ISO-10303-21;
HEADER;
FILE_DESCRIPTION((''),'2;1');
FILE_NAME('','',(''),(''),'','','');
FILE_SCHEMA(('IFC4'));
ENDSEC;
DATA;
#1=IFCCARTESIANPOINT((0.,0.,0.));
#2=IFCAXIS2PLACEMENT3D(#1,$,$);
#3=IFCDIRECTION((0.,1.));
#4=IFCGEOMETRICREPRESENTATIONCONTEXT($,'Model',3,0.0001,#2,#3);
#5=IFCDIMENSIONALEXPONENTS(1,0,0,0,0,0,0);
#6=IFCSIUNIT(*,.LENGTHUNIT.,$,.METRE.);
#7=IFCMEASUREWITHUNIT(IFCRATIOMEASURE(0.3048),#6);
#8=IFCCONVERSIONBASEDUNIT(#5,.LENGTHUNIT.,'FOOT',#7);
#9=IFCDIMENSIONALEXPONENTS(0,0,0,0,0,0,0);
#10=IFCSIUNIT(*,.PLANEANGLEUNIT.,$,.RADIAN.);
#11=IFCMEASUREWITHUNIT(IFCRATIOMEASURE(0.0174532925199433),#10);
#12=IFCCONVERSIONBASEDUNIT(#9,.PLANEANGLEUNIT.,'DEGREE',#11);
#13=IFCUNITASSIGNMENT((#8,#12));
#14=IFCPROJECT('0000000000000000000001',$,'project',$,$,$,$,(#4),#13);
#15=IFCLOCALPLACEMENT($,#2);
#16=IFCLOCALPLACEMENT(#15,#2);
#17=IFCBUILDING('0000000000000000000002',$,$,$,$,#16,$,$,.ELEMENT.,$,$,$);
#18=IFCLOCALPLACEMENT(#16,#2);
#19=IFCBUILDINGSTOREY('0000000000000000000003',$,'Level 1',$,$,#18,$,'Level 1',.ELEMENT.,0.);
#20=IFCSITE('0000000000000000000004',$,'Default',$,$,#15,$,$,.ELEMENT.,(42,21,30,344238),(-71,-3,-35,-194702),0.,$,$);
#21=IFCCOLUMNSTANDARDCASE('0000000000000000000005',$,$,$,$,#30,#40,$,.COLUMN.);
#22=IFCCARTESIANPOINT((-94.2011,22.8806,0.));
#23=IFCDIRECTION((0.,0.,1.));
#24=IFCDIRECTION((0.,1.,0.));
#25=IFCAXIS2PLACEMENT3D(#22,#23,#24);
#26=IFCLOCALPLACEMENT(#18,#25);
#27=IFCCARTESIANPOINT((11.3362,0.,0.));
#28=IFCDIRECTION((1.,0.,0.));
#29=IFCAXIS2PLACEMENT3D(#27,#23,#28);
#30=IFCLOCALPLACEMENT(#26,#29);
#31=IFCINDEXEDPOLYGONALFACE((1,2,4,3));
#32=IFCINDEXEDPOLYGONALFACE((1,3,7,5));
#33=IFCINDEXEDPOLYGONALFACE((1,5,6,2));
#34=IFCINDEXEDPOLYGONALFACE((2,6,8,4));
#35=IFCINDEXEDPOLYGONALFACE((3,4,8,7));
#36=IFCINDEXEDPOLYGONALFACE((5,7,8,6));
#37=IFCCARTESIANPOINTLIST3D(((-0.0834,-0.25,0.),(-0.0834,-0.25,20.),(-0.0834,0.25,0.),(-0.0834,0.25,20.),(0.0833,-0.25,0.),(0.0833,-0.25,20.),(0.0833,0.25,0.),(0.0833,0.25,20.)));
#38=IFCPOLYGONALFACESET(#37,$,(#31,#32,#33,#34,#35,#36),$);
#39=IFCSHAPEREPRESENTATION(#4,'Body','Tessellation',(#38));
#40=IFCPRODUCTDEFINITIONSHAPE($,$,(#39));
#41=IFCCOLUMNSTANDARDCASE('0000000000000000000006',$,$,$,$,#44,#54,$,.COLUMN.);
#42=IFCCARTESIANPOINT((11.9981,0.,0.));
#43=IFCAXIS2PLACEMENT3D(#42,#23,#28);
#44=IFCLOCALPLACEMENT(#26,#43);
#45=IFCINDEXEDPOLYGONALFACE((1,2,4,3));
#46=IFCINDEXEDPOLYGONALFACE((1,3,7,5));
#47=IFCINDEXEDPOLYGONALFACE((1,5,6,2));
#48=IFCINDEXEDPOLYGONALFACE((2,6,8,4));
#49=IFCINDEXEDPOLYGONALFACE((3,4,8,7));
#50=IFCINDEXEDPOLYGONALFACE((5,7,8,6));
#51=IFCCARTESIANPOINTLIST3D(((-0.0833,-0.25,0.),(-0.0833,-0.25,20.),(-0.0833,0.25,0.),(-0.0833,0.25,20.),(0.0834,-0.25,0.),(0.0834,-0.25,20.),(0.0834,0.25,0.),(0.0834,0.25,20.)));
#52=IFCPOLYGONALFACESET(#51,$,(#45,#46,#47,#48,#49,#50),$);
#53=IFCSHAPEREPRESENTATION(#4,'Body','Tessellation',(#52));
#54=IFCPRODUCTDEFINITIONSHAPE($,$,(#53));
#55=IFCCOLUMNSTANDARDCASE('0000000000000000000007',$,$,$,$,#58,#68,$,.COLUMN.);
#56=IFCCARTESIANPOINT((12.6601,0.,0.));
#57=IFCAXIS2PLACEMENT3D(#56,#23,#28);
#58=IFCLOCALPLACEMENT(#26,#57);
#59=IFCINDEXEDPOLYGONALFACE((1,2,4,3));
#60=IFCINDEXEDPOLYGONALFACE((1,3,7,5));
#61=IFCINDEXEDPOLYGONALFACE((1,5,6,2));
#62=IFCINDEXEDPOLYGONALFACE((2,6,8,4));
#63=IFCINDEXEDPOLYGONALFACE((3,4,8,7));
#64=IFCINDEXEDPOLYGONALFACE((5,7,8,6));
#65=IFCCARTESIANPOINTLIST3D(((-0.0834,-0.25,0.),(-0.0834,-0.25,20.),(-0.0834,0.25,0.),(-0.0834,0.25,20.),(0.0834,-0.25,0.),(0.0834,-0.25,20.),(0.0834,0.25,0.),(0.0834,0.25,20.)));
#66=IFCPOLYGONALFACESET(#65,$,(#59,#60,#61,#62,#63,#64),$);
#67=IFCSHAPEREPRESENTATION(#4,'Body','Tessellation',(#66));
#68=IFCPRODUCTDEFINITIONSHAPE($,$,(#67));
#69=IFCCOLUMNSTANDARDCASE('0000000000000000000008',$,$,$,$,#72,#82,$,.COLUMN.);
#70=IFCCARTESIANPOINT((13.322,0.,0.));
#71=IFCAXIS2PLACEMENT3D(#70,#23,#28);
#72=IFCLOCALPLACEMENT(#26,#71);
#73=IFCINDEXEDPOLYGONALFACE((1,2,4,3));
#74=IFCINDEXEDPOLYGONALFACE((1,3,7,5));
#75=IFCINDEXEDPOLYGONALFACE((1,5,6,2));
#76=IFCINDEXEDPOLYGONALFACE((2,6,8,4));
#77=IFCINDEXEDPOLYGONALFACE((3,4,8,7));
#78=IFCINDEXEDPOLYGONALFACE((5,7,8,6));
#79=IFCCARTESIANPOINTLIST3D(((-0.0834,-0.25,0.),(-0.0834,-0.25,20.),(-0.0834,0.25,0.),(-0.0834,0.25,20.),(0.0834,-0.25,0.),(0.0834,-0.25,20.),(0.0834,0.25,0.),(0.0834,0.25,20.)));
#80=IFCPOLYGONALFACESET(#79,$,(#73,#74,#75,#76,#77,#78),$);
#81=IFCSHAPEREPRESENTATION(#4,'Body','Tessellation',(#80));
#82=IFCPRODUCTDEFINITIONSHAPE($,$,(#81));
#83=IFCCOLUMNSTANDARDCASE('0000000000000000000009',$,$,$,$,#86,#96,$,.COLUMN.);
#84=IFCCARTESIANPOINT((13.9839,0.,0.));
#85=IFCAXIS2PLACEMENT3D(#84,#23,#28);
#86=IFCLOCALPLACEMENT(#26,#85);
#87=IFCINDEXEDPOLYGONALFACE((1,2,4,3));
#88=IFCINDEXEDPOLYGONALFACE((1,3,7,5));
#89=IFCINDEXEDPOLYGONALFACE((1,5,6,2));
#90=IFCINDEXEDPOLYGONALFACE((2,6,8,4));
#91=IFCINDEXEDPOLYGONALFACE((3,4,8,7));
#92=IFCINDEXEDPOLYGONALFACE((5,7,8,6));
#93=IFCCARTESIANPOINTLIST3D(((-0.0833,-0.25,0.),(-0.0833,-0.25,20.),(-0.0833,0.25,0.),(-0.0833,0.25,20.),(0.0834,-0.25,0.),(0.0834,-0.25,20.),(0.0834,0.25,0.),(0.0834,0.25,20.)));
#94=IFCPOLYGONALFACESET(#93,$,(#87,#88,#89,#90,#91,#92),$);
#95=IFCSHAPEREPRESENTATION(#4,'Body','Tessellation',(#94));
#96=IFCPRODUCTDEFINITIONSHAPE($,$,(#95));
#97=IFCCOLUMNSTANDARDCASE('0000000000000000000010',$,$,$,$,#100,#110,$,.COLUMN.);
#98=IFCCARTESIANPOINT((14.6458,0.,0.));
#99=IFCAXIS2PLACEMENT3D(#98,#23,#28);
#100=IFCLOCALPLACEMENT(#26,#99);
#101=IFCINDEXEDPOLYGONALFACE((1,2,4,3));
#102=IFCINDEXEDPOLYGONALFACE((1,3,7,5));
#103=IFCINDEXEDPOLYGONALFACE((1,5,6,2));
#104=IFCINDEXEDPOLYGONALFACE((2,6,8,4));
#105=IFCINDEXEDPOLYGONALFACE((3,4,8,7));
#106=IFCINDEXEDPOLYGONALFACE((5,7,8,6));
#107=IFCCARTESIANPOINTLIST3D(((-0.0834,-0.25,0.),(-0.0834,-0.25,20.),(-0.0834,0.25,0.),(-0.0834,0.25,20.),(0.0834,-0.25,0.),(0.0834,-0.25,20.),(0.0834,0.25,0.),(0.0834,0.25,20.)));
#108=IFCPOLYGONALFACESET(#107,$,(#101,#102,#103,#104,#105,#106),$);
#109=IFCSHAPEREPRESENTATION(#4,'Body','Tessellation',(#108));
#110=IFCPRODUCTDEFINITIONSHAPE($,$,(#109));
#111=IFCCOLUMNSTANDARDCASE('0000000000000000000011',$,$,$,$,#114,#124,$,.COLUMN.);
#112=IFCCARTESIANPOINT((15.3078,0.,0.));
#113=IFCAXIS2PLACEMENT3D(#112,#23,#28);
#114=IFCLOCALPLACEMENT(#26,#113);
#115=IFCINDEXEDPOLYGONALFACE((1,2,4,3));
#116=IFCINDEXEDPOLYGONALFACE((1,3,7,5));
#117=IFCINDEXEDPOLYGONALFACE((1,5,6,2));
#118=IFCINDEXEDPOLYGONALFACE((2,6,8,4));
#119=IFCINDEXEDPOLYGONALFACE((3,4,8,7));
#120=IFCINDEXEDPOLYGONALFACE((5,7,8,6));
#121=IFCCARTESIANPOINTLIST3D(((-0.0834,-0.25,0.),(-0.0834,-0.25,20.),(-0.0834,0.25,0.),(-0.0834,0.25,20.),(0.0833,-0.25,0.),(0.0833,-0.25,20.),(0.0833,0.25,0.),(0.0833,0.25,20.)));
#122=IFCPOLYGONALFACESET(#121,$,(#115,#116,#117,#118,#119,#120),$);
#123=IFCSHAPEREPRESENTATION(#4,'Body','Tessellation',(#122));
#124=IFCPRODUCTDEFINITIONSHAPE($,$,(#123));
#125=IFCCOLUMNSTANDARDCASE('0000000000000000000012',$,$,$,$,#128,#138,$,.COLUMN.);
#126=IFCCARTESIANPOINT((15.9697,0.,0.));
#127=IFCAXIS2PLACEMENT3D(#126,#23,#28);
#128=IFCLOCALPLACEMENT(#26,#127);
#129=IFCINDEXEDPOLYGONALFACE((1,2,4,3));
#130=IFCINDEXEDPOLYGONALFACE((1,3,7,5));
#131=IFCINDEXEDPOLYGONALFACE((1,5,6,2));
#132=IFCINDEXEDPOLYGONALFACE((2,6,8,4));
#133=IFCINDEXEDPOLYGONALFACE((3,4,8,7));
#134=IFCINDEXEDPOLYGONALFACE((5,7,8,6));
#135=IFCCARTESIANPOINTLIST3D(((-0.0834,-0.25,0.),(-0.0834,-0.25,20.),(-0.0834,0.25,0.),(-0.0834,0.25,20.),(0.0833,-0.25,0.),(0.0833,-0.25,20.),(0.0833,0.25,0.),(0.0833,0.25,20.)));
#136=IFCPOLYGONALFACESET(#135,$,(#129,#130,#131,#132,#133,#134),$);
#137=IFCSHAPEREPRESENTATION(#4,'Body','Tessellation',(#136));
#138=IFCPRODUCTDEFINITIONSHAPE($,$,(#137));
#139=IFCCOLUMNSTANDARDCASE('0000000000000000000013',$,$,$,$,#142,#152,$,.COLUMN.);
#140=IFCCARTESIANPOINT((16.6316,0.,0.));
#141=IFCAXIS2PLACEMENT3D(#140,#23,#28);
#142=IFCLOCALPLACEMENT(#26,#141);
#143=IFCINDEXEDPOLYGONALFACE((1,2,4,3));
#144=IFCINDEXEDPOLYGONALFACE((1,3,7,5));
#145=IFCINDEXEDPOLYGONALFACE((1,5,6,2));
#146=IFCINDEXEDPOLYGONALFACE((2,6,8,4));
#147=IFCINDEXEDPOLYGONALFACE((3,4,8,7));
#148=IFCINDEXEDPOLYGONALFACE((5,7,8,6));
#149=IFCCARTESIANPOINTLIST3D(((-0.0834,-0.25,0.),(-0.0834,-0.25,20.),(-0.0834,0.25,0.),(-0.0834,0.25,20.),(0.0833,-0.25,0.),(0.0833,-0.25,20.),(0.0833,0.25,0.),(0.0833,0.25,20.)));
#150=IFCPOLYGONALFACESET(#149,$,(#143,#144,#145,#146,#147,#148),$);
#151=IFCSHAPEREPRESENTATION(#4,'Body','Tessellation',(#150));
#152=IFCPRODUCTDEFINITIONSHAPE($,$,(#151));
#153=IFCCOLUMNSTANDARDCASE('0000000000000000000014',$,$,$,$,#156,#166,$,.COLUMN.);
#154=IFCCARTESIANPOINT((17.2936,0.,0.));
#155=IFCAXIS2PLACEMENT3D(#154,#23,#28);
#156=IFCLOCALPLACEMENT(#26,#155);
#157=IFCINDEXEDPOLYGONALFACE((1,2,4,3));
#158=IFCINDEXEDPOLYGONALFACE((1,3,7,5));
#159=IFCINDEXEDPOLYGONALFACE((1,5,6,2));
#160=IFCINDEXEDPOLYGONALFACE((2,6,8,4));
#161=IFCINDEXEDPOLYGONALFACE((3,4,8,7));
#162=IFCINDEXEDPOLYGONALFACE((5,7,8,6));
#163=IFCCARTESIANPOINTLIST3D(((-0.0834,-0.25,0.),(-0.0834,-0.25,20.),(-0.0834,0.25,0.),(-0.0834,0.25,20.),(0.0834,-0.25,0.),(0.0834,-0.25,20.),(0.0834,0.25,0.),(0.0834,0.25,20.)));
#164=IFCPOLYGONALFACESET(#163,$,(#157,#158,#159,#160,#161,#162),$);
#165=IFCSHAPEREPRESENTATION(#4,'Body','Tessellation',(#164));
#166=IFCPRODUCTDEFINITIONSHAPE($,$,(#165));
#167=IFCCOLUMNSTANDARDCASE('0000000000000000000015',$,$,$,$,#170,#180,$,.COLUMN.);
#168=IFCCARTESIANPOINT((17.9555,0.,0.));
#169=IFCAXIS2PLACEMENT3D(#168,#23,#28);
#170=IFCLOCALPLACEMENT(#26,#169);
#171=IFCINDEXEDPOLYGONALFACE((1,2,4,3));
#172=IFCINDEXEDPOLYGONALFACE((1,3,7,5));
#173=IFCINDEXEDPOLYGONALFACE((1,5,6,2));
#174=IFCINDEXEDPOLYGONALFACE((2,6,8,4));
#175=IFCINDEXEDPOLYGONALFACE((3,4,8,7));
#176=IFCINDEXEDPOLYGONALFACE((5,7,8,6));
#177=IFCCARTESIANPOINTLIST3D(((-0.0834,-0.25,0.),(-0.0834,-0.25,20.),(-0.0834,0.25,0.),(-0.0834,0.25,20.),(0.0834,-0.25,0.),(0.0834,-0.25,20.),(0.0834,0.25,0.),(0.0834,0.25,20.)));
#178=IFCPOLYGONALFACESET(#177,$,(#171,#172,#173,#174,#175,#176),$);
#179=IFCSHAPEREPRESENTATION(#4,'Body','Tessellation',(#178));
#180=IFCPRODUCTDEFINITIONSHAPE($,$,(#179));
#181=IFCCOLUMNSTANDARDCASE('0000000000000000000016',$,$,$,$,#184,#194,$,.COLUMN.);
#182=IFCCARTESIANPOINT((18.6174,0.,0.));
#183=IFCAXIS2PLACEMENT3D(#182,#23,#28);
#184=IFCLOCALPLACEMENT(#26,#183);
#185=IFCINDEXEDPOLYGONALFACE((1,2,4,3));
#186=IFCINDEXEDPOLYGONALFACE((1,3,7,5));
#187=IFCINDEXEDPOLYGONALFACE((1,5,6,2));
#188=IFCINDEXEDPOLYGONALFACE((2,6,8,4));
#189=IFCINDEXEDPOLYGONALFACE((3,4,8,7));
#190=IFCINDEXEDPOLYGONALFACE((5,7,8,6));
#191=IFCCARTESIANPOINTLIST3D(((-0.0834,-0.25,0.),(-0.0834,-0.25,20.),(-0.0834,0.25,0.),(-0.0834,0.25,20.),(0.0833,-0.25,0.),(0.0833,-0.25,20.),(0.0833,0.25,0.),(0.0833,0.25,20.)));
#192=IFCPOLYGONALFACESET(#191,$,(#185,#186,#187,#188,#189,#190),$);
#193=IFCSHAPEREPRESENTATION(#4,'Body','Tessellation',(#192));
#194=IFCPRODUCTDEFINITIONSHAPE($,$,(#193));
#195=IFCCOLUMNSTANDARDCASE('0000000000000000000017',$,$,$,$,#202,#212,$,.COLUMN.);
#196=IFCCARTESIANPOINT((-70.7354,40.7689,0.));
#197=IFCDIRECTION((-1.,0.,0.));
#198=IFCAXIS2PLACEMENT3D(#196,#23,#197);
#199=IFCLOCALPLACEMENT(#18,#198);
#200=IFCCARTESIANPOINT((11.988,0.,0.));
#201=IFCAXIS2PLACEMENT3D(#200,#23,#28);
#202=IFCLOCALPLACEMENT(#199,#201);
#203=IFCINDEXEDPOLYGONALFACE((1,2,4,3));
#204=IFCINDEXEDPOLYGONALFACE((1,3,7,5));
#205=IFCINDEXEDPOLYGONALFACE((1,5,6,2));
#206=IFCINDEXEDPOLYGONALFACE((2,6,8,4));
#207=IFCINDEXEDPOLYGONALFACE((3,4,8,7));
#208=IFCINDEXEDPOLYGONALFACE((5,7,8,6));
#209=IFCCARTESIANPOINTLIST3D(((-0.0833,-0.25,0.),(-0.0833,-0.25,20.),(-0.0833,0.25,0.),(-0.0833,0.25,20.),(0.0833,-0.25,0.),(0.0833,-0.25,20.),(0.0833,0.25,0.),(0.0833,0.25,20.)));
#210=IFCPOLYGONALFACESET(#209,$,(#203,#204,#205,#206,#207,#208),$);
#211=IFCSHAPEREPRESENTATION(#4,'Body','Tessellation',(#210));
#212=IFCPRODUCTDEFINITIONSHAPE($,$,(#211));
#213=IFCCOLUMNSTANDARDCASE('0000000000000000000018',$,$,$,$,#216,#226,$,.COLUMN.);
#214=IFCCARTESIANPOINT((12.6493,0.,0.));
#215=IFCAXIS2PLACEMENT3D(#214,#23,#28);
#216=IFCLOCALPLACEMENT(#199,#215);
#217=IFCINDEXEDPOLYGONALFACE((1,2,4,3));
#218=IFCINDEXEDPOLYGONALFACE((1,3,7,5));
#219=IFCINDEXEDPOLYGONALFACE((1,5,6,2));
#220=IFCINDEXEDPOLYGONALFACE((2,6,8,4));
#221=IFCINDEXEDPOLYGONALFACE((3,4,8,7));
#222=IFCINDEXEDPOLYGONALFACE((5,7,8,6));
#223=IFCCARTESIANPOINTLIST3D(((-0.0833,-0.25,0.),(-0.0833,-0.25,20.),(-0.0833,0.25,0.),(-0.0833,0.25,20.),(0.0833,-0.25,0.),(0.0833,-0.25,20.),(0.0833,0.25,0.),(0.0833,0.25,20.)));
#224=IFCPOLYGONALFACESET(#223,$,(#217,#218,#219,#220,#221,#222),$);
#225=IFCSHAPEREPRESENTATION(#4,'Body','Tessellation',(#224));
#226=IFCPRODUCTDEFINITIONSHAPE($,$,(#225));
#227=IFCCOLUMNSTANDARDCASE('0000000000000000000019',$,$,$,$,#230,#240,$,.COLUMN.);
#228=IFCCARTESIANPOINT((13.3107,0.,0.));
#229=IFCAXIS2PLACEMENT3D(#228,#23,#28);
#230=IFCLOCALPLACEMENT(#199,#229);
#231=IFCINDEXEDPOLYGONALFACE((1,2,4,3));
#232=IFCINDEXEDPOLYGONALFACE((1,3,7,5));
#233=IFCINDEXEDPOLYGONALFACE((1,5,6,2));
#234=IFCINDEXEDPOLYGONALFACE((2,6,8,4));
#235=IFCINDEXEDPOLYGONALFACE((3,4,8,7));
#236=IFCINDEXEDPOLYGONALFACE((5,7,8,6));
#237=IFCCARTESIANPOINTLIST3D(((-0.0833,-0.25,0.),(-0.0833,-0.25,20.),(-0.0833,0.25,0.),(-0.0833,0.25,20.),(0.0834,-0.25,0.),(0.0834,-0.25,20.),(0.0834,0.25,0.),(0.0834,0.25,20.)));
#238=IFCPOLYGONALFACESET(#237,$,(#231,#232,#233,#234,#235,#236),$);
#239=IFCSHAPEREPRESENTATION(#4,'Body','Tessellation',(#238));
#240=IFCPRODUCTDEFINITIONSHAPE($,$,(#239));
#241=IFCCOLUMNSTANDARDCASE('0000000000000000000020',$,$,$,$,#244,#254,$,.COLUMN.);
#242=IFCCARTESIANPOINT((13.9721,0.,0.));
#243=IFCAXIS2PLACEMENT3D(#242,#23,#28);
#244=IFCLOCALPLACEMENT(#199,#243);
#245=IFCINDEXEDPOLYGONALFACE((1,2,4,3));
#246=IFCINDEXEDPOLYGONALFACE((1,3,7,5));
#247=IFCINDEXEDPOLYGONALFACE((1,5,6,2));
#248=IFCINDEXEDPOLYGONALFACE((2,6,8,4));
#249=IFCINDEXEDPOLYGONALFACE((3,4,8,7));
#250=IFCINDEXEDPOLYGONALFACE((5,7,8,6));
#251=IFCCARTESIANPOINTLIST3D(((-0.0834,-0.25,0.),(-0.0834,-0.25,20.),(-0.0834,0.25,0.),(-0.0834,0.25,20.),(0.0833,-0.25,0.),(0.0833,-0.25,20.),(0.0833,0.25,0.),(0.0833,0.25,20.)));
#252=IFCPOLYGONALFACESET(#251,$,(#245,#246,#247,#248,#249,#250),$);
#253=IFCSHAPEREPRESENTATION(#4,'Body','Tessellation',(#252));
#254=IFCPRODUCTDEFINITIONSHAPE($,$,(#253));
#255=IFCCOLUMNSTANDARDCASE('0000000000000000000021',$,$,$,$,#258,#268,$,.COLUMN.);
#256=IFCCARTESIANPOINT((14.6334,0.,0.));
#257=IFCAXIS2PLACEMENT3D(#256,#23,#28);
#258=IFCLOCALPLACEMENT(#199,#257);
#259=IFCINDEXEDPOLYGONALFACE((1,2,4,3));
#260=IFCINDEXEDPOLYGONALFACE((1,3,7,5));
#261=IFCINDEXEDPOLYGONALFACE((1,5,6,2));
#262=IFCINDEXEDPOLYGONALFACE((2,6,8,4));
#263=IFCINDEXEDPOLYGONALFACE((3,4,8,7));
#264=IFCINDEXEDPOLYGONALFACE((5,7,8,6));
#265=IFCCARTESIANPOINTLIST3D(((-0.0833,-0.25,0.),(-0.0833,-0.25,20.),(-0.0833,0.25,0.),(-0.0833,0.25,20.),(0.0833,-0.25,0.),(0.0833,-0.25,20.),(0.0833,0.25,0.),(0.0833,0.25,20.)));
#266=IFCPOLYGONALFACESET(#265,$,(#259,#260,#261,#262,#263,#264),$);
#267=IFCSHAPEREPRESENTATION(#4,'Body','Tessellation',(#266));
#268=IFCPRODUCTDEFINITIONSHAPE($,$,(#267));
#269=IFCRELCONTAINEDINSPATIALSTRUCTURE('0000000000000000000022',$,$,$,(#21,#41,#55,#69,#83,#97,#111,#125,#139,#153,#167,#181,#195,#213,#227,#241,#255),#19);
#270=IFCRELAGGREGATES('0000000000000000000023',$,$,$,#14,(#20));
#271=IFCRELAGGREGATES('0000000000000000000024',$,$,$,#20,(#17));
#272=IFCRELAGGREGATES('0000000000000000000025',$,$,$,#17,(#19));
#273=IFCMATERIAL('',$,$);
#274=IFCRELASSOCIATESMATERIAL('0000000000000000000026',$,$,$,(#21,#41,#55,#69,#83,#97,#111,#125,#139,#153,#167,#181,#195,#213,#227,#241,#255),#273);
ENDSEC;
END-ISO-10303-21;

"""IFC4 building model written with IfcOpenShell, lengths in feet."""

from ifc_helpers import new_model, entity, si_unit, converted_unit, direction, frame, origin, place, context, project, spatial, rectangle, extrude, material, element, save


model = new_model("IFC4")

# Units and contexts
model_context = context("Model", 3, precision=0.0001, world=origin(), true_north=direction((0.0, 1.0)))
ifc_project = project(units=[converted_unit("LENGTHUNIT", "FOOT", entity("IfcRatioMeasure", 0.3048), si_unit("LENGTHUNIT", "METRE"), dimensions=[1, 0, 0, 0, 0, 0, 0]), converted_unit("PLANEANGLEUNIT", "DEGREE", entity("IfcRatioMeasure", 0.0174532925199433), si_unit("PLANEANGLEUNIT", "RADIAN"), dimensions=[0, 0, 0, 0, 0, 0, 0])], contexts=[model_context])

# Site, building, storey
site_placement = place(None, origin())
site = spatial("IfcSite", under=ifc_project, at=site_placement, Name="Default", CompositionType="ELEMENT", RefLatitude=(42, 21, 30, 344238), RefLongitude=(-71, -3, -35, -194702), RefElevation=0.0)
building_placement = place(site_placement, origin())
building = spatial("IfcBuilding", under=site, at=building_placement, CompositionType="ELEMENT")
storey_placement = place(building_placement, origin())
storey = spatial("IfcBuildingStorey", under=building, at=storey_placement, Name="Level 1", LongName="Level 1", CompositionType="ELEMENT", Elevation=0.0)

# Columns
ifc_material_1 = material(Name="")
placement_1 = place(storey_placement, frame((-94.2011, 22.8806, 0.0), z_axis=(0.0, 0.0, 1.0), x_axis=(0.0, 1.0, 0.0)))
for number, where, z_axis, x_axis in (
    (1, (11.3362, 0.0, 0.0), (0.0, 0.0, 1.0), (1.0, 0.0, 0.0)),
    (2, (11.9981, 0.0, 0.0), (0.0, 0.0, 1.0), (1.0, 0.0, 0.0)),
    (3, (12.6601, 0.0, 0.0), (0.0, 0.0, 1.0), (1.0, 0.0, 0.0)),
    (4, (13.322, 0.0, 0.0), (0.0, 0.0, 1.0), (1.0, 0.0, 0.0)),
    (5, (13.9839, 0.0, 0.0), (0.0, 0.0, 1.0), (1.0, 0.0, 0.0)),
    (6, (14.6458, 0.0, 0.0), (0.0, 0.0, 1.0), (1.0, 0.0, 0.0)),
    (7, (15.3078, 0.0, 0.0), (0.0, 0.0, 1.0), (1.0, 0.0, 0.0)),
    (8, (15.9697, 0.0, 0.0), (0.0, 0.0, 1.0), (1.0, 0.0, 0.0)),
    (9, (16.6316, 0.0, 0.0), (0.0, 0.0, 1.0), (1.0, 0.0, 0.0)),
    (10, (17.2936, 0.0, 0.0), (0.0, 0.0, 1.0), (1.0, 0.0, 0.0)),
    (11, (17.9555, 0.0, 0.0), (0.0, 0.0, 1.0), (1.0, 0.0, 0.0)),
    (12, (18.6174, 0.0, 0.0), (0.0, 0.0, 1.0), (1.0, 0.0, 0.0)),
):
    element("IfcColumnStandardCase", number, at=place(placement_1, frame(where, z_axis=z_axis, x_axis=x_axis)), inside=storey, material=ifc_material_1, PredefinedType="COLUMN", context=model_context, shape_type="SweptSolid", body=[
        extrude(rectangle(XDim=0.1667, YDim=0.5), origin(), (0.0, 0.0, 1.0), 20.0),
    ])
placement_2 = place(storey_placement, frame((-70.7354, 40.7689, 0.0), z_axis=(0.0, 0.0, 1.0), x_axis=(-1.0, 0.0, 0.0)))
for number, where, z_axis, x_axis in (
    (13, (11.988, 0.0, 0.0), (0.0, 0.0, 1.0), (1.0, 0.0, 0.0)),
    (14, (12.6493, 0.0, 0.0), (0.0, 0.0, 1.0), (1.0, 0.0, 0.0)),
    (15, (13.3107, 0.0, 0.0), (0.0, 0.0, 1.0), (1.0, 0.0, 0.0)),
    (16, (13.9721, 0.0, 0.0), (0.0, 0.0, 1.0), (1.0, 0.0, 0.0)),
    (17, (14.6334, 0.0, 0.0), (0.0, 0.0, 1.0), (1.0, 0.0, 0.0)),
):
    element("IfcColumnStandardCase", number, at=place(placement_2, frame(where, z_axis=z_axis, x_axis=x_axis)), inside=storey, material=ifc_material_1, PredefinedType="COLUMN", context=model_context, shape_type="SweptSolid", body=[
        extrude(rectangle(XDim=0.1667, YDim=0.5), origin(), (0.0, 0.0, 1.0), 20.0),
    ])

save(model, "model.ifc")
